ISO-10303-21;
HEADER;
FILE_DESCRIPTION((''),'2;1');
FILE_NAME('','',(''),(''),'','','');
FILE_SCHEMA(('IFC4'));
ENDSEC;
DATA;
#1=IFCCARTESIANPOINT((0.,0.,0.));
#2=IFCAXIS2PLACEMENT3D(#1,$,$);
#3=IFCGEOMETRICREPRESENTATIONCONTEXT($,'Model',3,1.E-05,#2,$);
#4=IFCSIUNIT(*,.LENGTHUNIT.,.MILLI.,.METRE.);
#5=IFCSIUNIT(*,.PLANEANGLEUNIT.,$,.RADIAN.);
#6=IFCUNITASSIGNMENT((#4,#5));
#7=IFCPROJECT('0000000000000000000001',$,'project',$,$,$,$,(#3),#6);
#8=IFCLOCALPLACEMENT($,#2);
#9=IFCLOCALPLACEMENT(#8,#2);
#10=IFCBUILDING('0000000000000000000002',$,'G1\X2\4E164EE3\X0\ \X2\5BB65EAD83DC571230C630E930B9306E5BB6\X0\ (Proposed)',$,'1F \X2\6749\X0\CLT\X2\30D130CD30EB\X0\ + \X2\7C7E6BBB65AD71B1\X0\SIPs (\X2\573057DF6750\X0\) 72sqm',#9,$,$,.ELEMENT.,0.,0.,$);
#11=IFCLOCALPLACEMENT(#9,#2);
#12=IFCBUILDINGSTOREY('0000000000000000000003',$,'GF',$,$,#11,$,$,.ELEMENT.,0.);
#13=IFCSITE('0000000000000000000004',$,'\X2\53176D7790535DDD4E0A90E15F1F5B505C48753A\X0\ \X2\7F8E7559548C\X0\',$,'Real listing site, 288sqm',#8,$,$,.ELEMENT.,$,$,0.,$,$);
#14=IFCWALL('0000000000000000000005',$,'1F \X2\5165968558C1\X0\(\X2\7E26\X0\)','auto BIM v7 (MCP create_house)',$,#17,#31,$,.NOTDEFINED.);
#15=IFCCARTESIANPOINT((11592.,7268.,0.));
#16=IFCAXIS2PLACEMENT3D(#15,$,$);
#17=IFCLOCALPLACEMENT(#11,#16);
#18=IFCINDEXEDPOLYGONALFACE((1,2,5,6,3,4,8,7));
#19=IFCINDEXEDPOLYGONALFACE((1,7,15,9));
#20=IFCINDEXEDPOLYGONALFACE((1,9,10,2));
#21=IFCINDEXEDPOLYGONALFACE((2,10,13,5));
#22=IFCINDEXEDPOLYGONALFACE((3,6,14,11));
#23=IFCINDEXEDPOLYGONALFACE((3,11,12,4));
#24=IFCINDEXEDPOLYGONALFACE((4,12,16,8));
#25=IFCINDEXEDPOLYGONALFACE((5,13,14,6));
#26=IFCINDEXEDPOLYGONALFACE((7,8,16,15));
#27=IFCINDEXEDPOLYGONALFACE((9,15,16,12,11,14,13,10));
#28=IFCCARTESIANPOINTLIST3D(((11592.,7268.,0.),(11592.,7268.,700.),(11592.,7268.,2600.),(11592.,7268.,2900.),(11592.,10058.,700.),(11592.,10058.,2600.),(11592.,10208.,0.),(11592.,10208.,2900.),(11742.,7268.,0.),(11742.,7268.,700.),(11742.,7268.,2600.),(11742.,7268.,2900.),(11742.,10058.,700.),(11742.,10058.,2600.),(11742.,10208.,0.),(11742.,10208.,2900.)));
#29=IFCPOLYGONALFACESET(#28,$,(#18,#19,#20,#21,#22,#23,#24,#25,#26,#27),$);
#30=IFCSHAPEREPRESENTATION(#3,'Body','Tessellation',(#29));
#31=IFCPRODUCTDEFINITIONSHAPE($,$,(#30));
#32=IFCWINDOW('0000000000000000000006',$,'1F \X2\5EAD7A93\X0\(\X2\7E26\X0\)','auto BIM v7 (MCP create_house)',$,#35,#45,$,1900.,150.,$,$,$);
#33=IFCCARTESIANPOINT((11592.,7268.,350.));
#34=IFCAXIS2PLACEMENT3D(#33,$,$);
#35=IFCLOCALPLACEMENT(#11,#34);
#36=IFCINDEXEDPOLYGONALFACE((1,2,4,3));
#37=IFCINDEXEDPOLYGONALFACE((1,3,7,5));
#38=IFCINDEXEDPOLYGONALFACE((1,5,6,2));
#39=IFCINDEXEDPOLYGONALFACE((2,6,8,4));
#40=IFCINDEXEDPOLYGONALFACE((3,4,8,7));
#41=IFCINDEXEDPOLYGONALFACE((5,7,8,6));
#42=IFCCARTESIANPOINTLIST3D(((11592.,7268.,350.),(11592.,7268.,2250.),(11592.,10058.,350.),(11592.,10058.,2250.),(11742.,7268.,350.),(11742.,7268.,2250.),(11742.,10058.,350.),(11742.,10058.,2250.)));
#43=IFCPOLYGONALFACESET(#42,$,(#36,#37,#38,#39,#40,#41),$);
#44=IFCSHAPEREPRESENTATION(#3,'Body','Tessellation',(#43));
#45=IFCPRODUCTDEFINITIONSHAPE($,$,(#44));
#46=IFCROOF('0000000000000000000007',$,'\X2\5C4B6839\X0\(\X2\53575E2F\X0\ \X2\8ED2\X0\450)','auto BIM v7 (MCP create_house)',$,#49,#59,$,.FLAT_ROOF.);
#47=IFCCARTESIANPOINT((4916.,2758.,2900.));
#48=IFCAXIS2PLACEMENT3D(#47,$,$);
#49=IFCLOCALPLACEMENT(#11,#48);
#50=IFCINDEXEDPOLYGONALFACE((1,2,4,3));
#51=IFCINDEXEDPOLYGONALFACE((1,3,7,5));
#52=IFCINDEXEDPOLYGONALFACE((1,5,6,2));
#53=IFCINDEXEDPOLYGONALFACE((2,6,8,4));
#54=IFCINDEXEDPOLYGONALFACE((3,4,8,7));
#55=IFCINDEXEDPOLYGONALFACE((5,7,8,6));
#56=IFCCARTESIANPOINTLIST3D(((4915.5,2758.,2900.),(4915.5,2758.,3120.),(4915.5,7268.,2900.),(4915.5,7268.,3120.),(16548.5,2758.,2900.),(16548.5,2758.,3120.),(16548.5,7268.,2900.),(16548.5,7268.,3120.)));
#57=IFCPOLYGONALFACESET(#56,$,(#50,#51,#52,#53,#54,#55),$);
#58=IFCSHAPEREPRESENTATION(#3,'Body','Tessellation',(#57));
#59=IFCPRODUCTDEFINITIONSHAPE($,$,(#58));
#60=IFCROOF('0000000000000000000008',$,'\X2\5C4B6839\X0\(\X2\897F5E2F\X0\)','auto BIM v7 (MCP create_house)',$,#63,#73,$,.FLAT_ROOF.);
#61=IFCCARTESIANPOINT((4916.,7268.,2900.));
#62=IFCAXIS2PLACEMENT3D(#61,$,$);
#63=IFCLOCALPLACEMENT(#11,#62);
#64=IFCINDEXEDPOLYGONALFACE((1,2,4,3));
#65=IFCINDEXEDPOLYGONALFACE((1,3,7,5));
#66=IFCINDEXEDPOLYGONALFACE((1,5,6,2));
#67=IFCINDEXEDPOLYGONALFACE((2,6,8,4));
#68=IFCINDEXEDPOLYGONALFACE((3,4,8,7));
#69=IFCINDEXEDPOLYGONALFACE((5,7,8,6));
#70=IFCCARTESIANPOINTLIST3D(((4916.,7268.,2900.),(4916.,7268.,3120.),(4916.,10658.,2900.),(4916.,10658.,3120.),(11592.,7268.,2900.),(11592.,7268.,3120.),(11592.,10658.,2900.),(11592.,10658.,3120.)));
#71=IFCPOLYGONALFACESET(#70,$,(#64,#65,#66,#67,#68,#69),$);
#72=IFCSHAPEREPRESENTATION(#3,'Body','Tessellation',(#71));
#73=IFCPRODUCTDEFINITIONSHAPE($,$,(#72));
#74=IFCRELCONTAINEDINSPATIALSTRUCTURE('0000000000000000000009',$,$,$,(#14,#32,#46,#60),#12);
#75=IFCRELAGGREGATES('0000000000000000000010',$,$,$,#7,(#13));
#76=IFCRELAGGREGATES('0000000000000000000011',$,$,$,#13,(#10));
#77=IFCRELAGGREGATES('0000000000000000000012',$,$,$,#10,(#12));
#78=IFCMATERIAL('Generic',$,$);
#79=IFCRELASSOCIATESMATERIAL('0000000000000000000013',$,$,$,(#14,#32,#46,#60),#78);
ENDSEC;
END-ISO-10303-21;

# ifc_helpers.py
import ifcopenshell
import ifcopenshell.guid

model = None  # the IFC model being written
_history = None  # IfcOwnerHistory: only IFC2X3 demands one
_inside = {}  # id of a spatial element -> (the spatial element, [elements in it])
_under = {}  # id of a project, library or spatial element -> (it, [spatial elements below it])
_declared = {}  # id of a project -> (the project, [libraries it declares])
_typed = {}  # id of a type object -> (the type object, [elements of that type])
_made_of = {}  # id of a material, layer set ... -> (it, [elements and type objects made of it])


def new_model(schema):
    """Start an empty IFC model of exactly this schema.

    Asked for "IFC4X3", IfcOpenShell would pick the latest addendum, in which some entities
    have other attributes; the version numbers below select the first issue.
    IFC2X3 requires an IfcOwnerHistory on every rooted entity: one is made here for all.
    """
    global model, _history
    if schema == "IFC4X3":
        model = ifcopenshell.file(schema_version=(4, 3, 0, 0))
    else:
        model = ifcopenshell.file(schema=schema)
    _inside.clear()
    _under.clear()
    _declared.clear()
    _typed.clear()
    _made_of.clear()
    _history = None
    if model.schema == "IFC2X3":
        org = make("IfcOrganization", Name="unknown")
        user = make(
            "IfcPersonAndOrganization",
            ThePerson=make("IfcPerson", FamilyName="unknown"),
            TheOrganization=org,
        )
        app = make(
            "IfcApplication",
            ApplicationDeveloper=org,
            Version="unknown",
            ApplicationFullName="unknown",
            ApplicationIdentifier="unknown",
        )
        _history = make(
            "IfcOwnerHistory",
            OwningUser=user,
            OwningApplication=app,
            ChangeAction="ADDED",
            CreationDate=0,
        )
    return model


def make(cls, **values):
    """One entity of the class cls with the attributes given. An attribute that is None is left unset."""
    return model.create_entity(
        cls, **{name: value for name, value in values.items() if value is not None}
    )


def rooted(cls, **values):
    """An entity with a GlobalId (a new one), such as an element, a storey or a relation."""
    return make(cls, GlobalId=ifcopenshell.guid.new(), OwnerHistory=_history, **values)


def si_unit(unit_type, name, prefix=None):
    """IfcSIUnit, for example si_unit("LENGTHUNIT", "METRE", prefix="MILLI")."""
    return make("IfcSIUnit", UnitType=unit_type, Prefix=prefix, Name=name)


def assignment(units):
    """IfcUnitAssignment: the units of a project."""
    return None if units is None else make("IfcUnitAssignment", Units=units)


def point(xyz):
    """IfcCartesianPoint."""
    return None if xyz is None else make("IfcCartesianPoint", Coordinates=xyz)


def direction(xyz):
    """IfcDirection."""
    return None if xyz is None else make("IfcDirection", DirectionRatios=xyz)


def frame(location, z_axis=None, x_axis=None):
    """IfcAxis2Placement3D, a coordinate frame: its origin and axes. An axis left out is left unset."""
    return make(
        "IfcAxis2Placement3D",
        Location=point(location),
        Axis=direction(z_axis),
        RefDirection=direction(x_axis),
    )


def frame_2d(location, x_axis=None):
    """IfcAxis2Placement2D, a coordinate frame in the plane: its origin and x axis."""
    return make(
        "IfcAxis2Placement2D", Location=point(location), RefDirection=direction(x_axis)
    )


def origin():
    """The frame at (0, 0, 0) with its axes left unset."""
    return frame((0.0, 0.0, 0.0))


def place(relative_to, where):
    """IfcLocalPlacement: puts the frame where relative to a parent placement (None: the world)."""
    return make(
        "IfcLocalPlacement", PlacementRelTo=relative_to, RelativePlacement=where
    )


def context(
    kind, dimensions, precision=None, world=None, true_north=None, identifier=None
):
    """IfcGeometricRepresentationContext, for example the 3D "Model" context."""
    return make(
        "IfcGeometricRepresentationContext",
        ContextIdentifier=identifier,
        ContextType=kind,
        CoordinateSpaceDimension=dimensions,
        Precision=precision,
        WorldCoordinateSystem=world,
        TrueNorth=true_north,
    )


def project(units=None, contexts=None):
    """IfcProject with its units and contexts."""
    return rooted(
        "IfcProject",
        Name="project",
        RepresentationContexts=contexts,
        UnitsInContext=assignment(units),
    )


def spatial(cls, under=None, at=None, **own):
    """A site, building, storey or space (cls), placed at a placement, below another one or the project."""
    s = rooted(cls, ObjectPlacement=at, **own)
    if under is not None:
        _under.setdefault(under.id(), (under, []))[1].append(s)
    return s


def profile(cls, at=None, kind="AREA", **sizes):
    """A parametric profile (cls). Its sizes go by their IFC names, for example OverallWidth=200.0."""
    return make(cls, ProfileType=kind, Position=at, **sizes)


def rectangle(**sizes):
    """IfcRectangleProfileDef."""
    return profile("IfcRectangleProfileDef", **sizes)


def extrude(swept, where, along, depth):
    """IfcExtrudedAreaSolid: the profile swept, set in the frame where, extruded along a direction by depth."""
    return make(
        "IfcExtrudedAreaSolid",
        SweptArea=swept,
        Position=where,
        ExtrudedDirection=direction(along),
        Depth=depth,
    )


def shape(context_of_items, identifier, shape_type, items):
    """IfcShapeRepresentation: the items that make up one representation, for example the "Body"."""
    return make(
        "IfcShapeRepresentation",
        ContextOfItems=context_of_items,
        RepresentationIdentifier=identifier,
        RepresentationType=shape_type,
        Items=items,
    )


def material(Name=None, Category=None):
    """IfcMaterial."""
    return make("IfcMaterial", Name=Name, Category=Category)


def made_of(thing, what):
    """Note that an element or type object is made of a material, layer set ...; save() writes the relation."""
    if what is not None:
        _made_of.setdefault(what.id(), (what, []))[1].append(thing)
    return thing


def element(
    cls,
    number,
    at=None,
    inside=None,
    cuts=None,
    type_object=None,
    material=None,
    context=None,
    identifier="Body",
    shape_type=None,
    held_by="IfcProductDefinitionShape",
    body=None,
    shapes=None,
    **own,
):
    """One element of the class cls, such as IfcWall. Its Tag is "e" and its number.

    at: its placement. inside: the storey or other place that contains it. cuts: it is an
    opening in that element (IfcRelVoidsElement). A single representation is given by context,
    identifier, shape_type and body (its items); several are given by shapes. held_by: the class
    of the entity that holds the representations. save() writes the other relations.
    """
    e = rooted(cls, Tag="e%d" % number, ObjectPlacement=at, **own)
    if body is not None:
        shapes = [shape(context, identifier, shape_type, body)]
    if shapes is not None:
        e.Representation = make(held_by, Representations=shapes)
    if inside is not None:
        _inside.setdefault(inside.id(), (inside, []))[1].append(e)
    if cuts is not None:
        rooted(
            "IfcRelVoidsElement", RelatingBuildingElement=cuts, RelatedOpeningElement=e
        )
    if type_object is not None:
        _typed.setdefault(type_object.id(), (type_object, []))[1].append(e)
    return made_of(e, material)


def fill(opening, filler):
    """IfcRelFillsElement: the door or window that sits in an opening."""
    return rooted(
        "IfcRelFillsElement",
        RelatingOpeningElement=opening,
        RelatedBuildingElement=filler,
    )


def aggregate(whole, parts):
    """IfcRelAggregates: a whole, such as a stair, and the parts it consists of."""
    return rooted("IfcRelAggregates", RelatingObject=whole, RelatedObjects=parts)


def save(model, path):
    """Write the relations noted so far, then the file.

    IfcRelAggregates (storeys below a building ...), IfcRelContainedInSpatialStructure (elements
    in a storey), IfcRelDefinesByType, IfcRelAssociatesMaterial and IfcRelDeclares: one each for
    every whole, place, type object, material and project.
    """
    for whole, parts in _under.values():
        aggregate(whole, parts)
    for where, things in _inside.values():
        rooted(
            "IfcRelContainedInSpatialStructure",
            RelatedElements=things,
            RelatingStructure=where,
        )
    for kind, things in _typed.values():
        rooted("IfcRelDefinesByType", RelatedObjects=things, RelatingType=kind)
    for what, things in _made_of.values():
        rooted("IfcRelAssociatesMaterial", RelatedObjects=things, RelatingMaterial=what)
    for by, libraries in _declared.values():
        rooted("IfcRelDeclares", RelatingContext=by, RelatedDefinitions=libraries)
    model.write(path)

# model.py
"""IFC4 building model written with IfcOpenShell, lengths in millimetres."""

from ifc_helpers import new_model, si_unit, frame, frame_2d, origin, place, context, project, spatial, rectangle, extrude, material, element, fill, save


model = new_model("IFC4")

# Units and contexts
model_context = context("Model", 3, precision=1e-05, world=origin())
ifc_project = project(units=[si_unit("LENGTHUNIT", "METRE", prefix="MILLI"), si_unit("PLANEANGLEUNIT", "RADIAN")], contexts=[model_context])

# Site, building, storey
site_placement = place(None, origin())
site = spatial("IfcSite", under=ifc_project, at=site_placement, Name="北海道川上郡弟子屈町 美留和", ObjectType="Real listing site, 288sqm", CompositionType="ELEMENT", RefElevation=0.0)
building_placement = place(site_placement, origin())
building = spatial("IfcBuilding", under=site, at=building_placement, Name="G1世代 家庭菜園テラスの家 (Proposed)", ObjectType="1F 杉CLTパネル + 籾殻断熱SIPs (地域材) 72sqm", CompositionType="ELEMENT", ElevationOfRefHeight=0.0, ElevationOfTerrain=0.0)
storey_placement = place(building_placement, origin())
storey = spatial("IfcBuildingStorey", under=building, at=storey_placement, Name="GF", CompositionType="ELEMENT", Elevation=0.0)

# Shared definitions
ifc_material = material(Name="Generic")

# Wall, opening, window
wall_1_placement = place(storey_placement, frame((11592.0, 7268.0, 0.0)))
wall_1 = element("IfcWall", 1, at=wall_1_placement, inside=storey, material=ifc_material, Name="1F 入隅壁(縦)", Description="auto BIM v7 (MCP create_house)", PredefinedType="NOTDEFINED", context=model_context, shape_type="SweptSolid", body=[
    extrude(rectangle(XDim=150.0, YDim=2940.0, at=frame_2d((75.0, 1470.0))), frame((11592.0, 7268.0, 0.0)), (0.0, 0.0, 1.0), 2900.0),
])
opening_1_placement = place(storey_placement, frame((11592.0, 7268.0, 350.0)))
opening_1 = element("IfcOpeningElement", 2, at=opening_1_placement, cuts=wall_1, PredefinedType="NOTDEFINED", context=model_context, shape_type="SweptSolid", body=[
    extrude(rectangle(XDim=150.0, YDim=2790.0, at=frame_2d((75.0, 1395.0))), frame((11592.0, 7268.0, 350.0)), (0.0, 0.0, 1.0), 1900.0),
])
window_1_placement = place(storey_placement, frame((11592.0, 7268.0, 350.0)))
window_1 = element("IfcWindow", 3, at=window_1_placement, inside=storey, material=ifc_material, Name="1F 庭窓(縦)", Description="auto BIM v7 (MCP create_house)", OverallHeight=1900.0, OverallWidth=150.0, context=model_context, shape_type="SweptSolid", body=[
    extrude(rectangle(XDim=150.0, YDim=2790.0, at=frame_2d((75.0, 1395.0))), frame((11592.0, 7268.0, 350.0)), (0.0, 0.0, 1.0), 1900.0),
])
fill(opening_1, window_1)

# Roofs
roof_1_placement = place(storey_placement, frame((4916.0, 2758.0, 2900.0)))
element("IfcRoof", 4, at=roof_1_placement, inside=storey, material=ifc_material, Name="屋根(南帯 軒450)", Description="auto BIM v7 (MCP create_house)", PredefinedType="FLAT_ROOF", context=model_context, shape_type="SweptSolid", body=[
    extrude(rectangle(XDim=11633.0, YDim=4510.0, at=frame_2d((5816.0, 2255.0))), frame((4916.0, 2758.0, 2900.0)), (0.0, 0.0, 1.0), 220.0),
])
roof_2_placement = place(storey_placement, frame((4916.0, 7268.0, 2900.0)))
element("IfcRoof", 5, at=roof_2_placement, inside=storey, material=ifc_material, Name="屋根(西帯)", Description="auto BIM v7 (MCP create_house)", PredefinedType="FLAT_ROOF", context=model_context, shape_type="SweptSolid", body=[
    extrude(rectangle(XDim=6676.0, YDim=3390.0, at=frame_2d((3338.0, 1695.0))), frame((4916.0, 7268.0, 2900.0)), (0.0, 0.0, 1.0), 220.0),
])

save(model, "model.ifc")
